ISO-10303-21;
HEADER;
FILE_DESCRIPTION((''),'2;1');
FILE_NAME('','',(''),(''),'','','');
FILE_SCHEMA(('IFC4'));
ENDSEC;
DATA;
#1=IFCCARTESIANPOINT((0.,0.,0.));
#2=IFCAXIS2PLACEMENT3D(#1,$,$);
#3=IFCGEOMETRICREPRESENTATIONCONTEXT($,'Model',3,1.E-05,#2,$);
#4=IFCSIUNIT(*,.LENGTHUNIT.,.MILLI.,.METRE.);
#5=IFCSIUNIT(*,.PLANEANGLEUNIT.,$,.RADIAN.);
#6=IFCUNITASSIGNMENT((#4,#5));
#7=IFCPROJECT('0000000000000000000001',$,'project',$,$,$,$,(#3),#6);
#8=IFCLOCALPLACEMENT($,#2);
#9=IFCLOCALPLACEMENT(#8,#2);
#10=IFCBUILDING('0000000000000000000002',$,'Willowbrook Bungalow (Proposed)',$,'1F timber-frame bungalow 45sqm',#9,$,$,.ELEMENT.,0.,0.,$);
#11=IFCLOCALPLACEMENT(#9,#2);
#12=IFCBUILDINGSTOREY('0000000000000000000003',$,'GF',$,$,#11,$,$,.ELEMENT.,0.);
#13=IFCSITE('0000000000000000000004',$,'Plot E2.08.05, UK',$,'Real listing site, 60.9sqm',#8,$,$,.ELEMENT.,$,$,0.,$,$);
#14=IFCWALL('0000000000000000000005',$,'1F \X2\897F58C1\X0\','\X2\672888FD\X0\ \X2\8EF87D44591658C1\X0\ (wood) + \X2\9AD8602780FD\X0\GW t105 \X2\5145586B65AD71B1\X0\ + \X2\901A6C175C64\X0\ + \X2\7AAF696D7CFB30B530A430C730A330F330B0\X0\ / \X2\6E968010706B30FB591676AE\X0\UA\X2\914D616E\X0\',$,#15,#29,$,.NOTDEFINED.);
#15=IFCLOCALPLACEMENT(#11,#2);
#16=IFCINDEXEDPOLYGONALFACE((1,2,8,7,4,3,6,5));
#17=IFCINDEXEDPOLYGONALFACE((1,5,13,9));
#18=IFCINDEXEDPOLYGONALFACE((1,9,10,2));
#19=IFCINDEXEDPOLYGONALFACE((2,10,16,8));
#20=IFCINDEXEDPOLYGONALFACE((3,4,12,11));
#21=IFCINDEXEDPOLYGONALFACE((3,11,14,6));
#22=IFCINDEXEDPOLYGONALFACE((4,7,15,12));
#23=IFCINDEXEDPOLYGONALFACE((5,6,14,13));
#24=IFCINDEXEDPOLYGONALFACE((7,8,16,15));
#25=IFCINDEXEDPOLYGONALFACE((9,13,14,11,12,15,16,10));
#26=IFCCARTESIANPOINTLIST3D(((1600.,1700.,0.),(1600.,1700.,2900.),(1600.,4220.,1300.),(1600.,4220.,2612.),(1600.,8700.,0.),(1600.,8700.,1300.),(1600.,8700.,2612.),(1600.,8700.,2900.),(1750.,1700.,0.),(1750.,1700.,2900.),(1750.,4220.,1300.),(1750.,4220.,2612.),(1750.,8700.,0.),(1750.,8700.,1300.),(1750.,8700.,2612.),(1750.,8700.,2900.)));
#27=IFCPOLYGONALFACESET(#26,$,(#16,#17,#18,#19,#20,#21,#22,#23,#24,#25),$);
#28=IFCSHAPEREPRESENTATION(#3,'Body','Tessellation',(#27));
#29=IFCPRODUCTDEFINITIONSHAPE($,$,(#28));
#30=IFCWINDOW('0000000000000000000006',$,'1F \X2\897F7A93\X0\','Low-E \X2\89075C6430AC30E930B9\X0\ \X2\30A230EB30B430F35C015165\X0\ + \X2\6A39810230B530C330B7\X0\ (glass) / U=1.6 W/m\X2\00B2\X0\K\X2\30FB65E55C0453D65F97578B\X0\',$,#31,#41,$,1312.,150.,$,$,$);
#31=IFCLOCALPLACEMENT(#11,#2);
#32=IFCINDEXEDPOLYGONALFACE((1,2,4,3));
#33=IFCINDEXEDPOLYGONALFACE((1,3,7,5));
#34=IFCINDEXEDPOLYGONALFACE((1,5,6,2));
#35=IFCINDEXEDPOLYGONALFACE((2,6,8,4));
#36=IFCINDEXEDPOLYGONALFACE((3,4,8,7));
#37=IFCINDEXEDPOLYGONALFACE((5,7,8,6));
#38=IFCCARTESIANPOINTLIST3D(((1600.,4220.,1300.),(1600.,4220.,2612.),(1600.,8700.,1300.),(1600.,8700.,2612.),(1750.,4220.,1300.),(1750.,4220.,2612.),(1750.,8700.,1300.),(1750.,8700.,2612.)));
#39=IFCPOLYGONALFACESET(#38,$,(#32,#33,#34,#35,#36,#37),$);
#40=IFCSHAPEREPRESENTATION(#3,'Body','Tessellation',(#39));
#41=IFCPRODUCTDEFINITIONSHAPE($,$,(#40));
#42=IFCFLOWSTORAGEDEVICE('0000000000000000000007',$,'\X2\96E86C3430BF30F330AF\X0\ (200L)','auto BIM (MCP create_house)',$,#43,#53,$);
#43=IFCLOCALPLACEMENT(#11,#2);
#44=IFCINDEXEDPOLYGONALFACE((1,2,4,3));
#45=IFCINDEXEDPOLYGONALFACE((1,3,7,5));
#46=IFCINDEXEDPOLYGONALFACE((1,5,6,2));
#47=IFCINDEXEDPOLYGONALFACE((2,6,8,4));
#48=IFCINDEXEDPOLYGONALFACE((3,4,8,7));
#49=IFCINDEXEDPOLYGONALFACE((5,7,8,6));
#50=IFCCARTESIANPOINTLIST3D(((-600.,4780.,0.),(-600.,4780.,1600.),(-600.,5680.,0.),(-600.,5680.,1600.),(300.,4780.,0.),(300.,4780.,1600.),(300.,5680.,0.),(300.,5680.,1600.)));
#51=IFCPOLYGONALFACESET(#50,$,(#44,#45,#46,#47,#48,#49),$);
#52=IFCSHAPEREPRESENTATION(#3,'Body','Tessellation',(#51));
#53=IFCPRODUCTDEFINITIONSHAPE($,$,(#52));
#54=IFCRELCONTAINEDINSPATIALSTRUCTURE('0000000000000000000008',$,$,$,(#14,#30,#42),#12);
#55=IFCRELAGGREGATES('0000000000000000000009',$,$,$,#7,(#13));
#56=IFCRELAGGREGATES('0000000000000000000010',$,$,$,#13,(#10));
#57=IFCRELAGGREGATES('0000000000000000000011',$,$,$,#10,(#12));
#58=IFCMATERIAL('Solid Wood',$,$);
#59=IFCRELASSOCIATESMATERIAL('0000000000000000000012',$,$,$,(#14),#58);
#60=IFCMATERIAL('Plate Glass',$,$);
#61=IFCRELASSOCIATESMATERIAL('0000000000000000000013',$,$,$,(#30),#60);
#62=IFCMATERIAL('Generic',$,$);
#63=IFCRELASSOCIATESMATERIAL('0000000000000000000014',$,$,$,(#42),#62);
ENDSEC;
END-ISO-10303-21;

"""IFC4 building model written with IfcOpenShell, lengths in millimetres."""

from ifc_helpers import new_model, si_unit, frame, frame_2d, origin, place, context, project, spatial, rectangle, extrude, material, element, fill, save


model = new_model("IFC4")

# Units and contexts
model_context = context("Model", 3, precision=1e-05, world=origin())
ifc_project = project(units=[si_unit("LENGTHUNIT", "METRE", prefix="MILLI"), si_unit("PLANEANGLEUNIT", "RADIAN")], contexts=[model_context])

# Site, building, storey
site_placement = place(None, origin())
site = spatial("IfcSite", under=ifc_project, at=site_placement, Name="Plot E2.08.05, UK", ObjectType="Real listing site, 60.9sqm", CompositionType="ELEMENT", RefElevation=0.0)
building_placement = place(site_placement, origin())
building = spatial("IfcBuilding", under=site, at=building_placement, Name="Willowbrook Bungalow (Proposed)", ObjectType="1F timber-frame bungalow 45sqm", CompositionType="ELEMENT", ElevationOfRefHeight=0.0, ElevationOfTerrain=0.0)
storey_placement = place(building_placement, origin())
storey = spatial("IfcBuildingStorey", under=building, at=storey_placement, Name="GF", CompositionType="ELEMENT", Elevation=0.0)

# Shared definitions
ifc_material_1 = material(Name="Solid Wood")

# Shared definitions
ifc_material_2 = material(Name="Plate Glass")

# Wall, opening, window
wall_1_placement = place(storey_placement, frame((800.0, 850.0, 0.0)))
wall_1 = element("IfcWall", 1, at=wall_1_placement, inside=storey, material=ifc_material_1, Name="1F 西壁", Description="木製 軸組外壁 (wood) + 高性能GW t105 充填断熱 + 通気層 + 窯業系サイディング / 準耐火・外皮UA配慮", PredefinedType="NOTDEFINED", context=model_context, shape_type="SweptSolid", body=[
    extrude(rectangle(XDim=150.0, YDim=7000.0, at=frame_2d((75.0, 3500.0))), frame((800.0, 850.0, 0.0)), (0.0, 0.0, 1.0), 2900.0),
])
opening_1_placement = place(storey_placement, frame((800.0, 2110.0, 650.0)))
opening_1 = element("IfcOpeningElement", 2, at=opening_1_placement, cuts=wall_1, PredefinedType="NOTDEFINED", context=model_context, shape_type="SweptSolid", body=[
    extrude(rectangle(XDim=150.0, YDim=4480.0, at=frame_2d((75.0, 2240.0))), frame((800.0, 2110.0, 650.0)), (0.0, 0.0, 1.0), 1312.0),
])
window_1_placement = place(storey_placement, frame((800.0, 2110.0, 650.0)))
window_1 = element("IfcWindow", 3, at=window_1_placement, inside=storey, material=ifc_material_2, Name="1F 西窓", Description="Low-E 複層ガラス アルゴン封入 + 樹脂サッシ (glass) / U=1.6 W/m²K・日射取得型", OverallHeight=1312.0, OverallWidth=150.0, context=model_context, shape_type="SweptSolid", body=[
    extrude(rectangle(XDim=150.0, YDim=4480.0, at=frame_2d((75.0, 2240.0))), frame((800.0, 2110.0, 650.0)), (0.0, 0.0, 1.0), 1312.0),
])
fill(opening_1, window_1)

# Shared definitions
ifc_material_3 = material(Name="Generic")

# Flow storage device
flow_storage_device_placement = place(storey_placement, frame((-300.0, 2390.0, 0.0)))
element("IfcFlowStorageDevice", 4, at=flow_storage_device_placement, inside=storey, material=ifc_material_3, Name="雨水タンク (200L)", Description="auto BIM (MCP create_house)", context=model_context, shape_type="SweptSolid", body=[
    extrude(rectangle(XDim=900.0, YDim=900.0, at=frame_2d((450.0, 450.0))), frame((-300.0, 2390.0, 0.0)), (0.0, 0.0, 1.0), 1600.0),
])

save(model, "model.ifc")
